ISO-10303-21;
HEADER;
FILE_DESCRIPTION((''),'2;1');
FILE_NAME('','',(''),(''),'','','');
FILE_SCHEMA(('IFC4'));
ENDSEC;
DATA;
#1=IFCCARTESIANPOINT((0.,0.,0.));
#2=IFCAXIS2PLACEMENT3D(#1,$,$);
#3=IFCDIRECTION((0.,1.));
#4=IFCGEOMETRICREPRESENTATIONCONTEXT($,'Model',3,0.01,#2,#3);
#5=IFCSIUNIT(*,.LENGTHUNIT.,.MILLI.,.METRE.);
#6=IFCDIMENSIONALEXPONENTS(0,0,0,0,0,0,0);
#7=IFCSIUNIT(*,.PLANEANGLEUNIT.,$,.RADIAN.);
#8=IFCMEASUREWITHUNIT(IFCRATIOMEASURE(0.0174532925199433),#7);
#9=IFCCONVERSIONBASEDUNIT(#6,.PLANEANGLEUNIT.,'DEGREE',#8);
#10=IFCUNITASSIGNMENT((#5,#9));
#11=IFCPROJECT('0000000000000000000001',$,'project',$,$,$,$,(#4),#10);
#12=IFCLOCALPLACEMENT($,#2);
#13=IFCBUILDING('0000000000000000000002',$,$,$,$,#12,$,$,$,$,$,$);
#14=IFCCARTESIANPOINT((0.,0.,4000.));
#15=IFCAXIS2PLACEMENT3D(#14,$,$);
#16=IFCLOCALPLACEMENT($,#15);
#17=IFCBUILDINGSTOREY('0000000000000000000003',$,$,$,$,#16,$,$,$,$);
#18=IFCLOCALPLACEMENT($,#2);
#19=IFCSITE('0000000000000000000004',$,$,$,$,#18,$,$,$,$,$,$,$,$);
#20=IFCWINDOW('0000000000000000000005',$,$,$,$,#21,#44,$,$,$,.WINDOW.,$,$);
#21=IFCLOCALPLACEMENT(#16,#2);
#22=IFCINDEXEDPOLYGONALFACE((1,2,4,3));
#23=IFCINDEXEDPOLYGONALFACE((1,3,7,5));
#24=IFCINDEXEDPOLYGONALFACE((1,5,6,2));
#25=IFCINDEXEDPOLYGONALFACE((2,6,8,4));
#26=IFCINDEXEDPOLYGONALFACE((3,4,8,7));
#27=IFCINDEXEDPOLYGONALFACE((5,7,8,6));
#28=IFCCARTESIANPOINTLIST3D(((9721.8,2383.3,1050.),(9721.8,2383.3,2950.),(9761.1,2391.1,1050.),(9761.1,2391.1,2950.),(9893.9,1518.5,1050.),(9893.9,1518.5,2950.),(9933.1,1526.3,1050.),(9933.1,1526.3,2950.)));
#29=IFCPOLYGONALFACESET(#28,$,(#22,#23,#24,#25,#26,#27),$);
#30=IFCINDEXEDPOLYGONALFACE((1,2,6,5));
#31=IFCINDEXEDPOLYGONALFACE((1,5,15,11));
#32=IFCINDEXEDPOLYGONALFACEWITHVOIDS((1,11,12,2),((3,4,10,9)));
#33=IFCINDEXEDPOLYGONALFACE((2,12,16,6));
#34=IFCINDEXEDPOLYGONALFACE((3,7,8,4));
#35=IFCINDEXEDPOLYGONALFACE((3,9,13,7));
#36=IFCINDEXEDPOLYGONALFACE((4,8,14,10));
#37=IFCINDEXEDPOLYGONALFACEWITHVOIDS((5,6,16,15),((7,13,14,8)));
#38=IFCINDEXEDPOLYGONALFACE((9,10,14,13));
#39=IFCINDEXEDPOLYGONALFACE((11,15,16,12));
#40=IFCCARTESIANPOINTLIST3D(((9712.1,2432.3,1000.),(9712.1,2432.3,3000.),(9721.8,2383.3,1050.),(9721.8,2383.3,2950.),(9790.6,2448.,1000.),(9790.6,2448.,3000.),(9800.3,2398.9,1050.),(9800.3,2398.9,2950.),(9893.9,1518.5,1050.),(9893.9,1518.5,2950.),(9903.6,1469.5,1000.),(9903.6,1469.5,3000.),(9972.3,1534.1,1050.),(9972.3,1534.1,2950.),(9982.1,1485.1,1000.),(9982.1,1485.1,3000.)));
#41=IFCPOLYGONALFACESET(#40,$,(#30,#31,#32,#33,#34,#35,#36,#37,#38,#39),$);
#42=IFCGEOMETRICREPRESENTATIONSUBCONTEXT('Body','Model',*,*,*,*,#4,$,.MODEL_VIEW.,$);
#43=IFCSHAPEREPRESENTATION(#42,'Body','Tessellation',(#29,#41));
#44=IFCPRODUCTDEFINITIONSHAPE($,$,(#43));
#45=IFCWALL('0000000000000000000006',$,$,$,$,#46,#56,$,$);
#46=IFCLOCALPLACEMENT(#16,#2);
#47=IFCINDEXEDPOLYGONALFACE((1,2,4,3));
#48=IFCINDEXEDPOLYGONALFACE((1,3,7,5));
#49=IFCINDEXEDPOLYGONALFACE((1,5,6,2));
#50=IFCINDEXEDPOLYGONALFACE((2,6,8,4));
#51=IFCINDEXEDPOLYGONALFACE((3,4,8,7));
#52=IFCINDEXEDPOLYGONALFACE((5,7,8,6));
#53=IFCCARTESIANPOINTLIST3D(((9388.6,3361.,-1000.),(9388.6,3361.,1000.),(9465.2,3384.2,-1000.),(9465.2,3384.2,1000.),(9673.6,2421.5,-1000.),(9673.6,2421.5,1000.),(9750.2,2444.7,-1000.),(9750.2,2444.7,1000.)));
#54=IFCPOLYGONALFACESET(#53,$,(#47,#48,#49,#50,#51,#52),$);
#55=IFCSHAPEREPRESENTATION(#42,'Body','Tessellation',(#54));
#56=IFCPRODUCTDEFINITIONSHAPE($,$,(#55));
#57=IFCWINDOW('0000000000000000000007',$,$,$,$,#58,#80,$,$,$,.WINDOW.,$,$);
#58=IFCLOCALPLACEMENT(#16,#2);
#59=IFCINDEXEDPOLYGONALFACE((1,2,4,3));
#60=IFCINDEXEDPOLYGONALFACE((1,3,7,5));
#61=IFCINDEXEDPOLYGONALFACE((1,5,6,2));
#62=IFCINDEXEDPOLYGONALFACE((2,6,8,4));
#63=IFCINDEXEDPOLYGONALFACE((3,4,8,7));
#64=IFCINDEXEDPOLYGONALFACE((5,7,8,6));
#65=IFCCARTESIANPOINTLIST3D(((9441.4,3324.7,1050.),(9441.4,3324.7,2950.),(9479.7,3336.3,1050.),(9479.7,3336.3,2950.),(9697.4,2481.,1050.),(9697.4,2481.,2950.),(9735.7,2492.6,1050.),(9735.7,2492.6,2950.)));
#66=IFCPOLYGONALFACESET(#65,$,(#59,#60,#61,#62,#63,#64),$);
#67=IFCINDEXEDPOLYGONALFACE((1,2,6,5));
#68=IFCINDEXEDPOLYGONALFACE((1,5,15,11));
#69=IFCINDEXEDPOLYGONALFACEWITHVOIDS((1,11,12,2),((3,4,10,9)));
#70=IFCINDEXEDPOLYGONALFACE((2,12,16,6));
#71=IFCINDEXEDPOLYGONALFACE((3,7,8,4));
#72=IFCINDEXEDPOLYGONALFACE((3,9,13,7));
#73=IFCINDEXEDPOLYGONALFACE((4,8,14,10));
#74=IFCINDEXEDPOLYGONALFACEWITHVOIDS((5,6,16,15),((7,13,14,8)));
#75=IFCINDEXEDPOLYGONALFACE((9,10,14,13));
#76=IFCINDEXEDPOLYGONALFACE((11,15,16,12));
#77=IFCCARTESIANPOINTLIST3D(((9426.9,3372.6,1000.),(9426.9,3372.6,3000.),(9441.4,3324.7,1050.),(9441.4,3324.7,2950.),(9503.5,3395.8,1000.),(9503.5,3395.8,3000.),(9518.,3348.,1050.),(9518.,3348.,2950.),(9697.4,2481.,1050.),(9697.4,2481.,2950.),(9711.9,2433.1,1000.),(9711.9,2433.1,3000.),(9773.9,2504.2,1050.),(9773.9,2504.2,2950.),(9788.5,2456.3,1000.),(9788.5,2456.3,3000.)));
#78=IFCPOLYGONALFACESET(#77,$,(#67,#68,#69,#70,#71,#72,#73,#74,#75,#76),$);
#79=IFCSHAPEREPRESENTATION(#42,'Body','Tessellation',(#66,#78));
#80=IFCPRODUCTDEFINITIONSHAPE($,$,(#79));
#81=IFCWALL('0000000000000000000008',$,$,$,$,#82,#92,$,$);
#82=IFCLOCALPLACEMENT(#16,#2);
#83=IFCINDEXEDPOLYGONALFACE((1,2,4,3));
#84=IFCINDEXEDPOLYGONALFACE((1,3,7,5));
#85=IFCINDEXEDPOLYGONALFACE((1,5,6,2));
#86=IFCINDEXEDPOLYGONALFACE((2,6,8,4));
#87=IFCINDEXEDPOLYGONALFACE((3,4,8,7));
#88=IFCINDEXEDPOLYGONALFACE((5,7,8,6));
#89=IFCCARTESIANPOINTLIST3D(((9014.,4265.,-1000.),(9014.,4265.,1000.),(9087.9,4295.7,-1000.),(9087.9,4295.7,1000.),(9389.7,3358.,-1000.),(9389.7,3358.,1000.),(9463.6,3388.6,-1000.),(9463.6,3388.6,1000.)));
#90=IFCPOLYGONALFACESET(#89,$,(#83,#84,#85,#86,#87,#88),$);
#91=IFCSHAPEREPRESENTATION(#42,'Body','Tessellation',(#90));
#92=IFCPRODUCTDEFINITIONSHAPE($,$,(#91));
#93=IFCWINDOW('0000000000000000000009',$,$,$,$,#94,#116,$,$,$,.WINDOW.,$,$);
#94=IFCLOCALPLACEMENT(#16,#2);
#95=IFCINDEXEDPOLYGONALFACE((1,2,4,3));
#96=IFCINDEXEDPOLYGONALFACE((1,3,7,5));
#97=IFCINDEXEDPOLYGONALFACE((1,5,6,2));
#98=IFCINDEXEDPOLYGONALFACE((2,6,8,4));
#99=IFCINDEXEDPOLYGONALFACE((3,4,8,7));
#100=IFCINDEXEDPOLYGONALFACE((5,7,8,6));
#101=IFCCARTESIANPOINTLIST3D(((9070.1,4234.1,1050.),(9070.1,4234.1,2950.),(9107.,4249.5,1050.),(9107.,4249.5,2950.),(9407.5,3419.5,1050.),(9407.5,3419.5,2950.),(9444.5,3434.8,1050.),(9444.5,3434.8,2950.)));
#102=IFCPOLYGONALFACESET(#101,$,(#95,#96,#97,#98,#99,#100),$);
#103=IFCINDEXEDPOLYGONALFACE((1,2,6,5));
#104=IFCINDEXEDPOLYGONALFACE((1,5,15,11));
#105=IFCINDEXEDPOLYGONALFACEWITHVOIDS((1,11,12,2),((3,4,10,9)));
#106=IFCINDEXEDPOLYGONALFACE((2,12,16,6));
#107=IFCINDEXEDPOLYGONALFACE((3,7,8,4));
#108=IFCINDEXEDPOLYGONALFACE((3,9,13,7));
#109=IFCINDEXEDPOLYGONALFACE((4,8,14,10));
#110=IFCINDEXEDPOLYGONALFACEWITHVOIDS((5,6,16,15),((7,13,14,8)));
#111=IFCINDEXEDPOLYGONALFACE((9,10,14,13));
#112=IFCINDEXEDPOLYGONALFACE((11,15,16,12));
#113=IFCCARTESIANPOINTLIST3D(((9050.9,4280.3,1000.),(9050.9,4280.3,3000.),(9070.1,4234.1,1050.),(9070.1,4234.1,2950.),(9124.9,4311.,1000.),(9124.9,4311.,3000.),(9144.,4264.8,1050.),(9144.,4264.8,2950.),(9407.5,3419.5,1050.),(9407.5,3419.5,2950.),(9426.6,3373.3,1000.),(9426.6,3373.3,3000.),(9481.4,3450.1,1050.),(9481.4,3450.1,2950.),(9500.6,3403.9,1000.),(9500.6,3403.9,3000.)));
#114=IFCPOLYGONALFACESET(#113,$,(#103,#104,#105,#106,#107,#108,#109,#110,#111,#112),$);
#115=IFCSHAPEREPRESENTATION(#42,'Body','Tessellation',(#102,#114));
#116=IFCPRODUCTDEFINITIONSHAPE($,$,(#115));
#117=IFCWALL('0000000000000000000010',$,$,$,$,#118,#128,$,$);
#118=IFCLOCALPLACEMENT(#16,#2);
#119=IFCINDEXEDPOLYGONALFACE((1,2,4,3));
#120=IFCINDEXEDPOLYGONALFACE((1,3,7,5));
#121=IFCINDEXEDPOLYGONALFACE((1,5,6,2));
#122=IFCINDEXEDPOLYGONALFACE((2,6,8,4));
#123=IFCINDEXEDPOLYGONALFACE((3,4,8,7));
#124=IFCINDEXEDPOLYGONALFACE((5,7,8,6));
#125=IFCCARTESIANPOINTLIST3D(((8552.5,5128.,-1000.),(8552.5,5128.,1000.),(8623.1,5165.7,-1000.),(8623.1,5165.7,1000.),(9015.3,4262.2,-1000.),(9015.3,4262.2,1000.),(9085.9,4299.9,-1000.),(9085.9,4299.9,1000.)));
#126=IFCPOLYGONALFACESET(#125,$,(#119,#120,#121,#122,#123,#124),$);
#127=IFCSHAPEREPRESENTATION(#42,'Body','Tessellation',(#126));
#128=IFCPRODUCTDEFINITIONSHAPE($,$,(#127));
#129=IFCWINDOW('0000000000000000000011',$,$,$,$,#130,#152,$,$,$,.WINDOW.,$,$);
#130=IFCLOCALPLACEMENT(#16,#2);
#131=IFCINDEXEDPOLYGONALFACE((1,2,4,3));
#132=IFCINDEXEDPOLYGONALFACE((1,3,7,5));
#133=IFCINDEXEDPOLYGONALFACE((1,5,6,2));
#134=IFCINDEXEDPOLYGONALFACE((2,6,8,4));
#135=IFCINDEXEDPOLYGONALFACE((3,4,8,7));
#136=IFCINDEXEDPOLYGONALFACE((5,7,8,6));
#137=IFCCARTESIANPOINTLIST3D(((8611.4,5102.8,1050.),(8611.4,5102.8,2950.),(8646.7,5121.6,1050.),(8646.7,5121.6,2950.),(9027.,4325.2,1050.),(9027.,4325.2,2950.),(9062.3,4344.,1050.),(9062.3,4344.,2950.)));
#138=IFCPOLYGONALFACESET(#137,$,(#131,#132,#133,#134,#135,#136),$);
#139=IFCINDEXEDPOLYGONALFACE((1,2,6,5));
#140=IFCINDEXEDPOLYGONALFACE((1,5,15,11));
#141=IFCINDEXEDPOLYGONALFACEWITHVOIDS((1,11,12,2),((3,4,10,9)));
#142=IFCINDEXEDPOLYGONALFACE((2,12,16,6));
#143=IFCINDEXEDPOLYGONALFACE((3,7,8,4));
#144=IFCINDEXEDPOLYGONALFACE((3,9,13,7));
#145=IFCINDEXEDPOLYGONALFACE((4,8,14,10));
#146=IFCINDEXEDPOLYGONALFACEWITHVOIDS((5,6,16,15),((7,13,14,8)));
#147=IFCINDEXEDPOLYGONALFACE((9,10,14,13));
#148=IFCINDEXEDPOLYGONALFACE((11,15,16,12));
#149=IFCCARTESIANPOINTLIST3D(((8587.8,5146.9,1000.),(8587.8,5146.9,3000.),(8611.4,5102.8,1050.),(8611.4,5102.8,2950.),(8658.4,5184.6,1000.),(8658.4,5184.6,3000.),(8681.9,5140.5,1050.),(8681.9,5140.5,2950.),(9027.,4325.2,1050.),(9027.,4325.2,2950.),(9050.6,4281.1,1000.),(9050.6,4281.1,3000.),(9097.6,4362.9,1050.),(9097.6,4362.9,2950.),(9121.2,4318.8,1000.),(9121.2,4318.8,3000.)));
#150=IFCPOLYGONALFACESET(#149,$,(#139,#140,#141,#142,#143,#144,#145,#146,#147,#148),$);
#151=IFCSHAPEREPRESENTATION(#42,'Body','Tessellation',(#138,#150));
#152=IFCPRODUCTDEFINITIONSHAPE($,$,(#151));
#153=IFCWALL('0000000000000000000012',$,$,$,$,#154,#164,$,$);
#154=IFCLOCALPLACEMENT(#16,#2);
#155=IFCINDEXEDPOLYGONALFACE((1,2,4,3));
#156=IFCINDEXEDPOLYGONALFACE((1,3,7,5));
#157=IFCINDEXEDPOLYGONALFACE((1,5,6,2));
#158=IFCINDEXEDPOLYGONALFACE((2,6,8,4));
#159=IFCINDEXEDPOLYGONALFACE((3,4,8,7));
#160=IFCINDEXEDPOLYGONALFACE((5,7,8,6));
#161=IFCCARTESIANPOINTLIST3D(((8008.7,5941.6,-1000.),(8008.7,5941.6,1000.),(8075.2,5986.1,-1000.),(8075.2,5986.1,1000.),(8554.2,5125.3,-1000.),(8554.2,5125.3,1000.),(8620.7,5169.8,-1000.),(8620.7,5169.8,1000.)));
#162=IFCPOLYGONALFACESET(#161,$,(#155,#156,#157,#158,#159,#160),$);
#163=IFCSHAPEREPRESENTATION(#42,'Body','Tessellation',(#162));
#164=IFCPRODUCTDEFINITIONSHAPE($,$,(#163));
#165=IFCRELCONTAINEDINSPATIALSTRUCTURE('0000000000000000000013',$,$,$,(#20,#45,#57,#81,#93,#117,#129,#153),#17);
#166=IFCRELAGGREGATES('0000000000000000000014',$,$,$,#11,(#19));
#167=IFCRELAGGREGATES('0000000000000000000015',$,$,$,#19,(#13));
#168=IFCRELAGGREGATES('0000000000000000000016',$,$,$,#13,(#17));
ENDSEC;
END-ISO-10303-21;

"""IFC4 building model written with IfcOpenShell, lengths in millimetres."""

from ifc_helpers import new_model, entity, si_unit, converted_unit, direction, frame, origin, origin_2d, place, context, subcontext, project, spatial, rectangle, extrude, element, save


model = new_model("IFC4")

# Units and contexts
model_context = context("Model", 3, precision=0.01, world=origin(), true_north=direction((0.0, 1.0)))
body_context = subcontext(model_context, "Body", "Model", "MODEL_VIEW")
ifc_project = project(units=[si_unit("LENGTHUNIT", "METRE", prefix="MILLI"), converted_unit("PLANEANGLEUNIT", "DEGREE", entity("IfcRatioMeasure", 0.0174532925199433), si_unit("PLANEANGLEUNIT", "RADIAN"), dimensions=[0, 0, 0, 0, 0, 0, 0])], contexts=[model_context])

# Site, building, storey
site_placement = place(None, origin())
site = spatial("IfcSite", under=ifc_project, at=site_placement)
building_placement = place(None, origin())
building = spatial("IfcBuilding", under=site, at=building_placement)
storey_placement = place(None, frame((0.0, 0.0, 4000.0)))
storey = spatial("IfcBuildingStorey", under=building, at=storey_placement)

# Shared definitions
cartesian_point_1 = entity("IfcCartesianPoint", [-440.9, -950.0])
shared_polyline = entity("IfcPolyline", [cartesian_point_1, entity("IfcCartesianPoint", [-440.9, 950.0]), entity("IfcCartesianPoint", [-440.9, 950.0]), entity("IfcCartesianPoint", [440.9, 950.0]), entity("IfcCartesianPoint", [440.9, 950.0]), entity("IfcCartesianPoint", [440.9, -950.0]), entity("IfcCartesianPoint", [440.9, -950.0]), entity("IfcCartesianPoint", [-440.9, -950.0]), cartesian_point_1])

# Window
window_1_placement = place(storey_placement, frame((9807.9, 1950.9, 2000.0), z_axis=(0.0, 0.0, 1.0), x_axis=(-1950.903274, 9807.852793, 0.0)))
cartesian_point_2 = entity("IfcCartesianPoint", [-490.9, -1000.0])
element("IfcWindow", 1, at=window_1_placement, inside=storey, PredefinedType="WINDOW", context=body_context, shape_type="SweptSolid", body=[
    entity("IfcExtrudedAreaSolid", entity("IfcArbitraryClosedProfileDef", "AREA", None, shared_polyline), entity("IfcAxis2Placement3D", entity("IfcCartesianPoint", [0.0, 0.0, 0.0]), entity("IfcDirection", [0.0, -1.0, 0.0]), entity("IfcDirection", [1.0, 0.0, 0.0])), entity("IfcDirection", [0.0, 0.0, 1.0]), 40.0),
    entity("IfcExtrudedAreaSolid", entity("IfcArbitraryProfileDefWithVoids", "AREA", None, entity("IfcPolyline", [cartesian_point_2, entity("IfcCartesianPoint", [-490.9, 1000.0]), entity("IfcCartesianPoint", [-490.9, 1000.0]), entity("IfcCartesianPoint", [490.9, 1000.0]), entity("IfcCartesianPoint", [490.9, 1000.0]), entity("IfcCartesianPoint", [490.9, -1000.0]), entity("IfcCartesianPoint", [490.9, -1000.0]), entity("IfcCartesianPoint", [-490.9, -1000.0]), cartesian_point_2]), [shared_polyline]), entity("IfcAxis2Placement3D", entity("IfcCartesianPoint", [0.0, 0.0, 0.0]), entity("IfcDirection", [0.0, -1.0, 0.0]), entity("IfcDirection", [1.0, 0.0, 0.0])), entity("IfcDirection", [0.0, 0.0, 1.0]), 80.0),
])

# Wall
wall_1_placement = place(storey_placement, frame((9569.4, 2902.8, -1000.0), z_axis=(0.0, 0.0, 1.0), x_axis=(-2902.84678, 9569.403355, 0.0)))
element("IfcWall", 2, at=wall_1_placement, inside=storey, context=body_context, shape_type="SweptSolid", body=[
    extrude(rectangle(XDim=981.7, YDim=80.0, at=origin_2d()), origin(), (0.0, 0.0, 1.0), 2000.0),
])

# Window
window_2_placement = place(storey_placement, frame((9569.4, 2902.8, 2000.0), z_axis=(0.0, 0.0, 1.0), x_axis=(-2902.84678, 9569.403355, 0.0)))
cartesian_point_3 = entity("IfcCartesianPoint", [-490.9, -1000.0])
element("IfcWindow", 3, at=window_2_placement, inside=storey, PredefinedType="WINDOW", context=body_context, shape_type="SweptSolid", body=[
    entity("IfcExtrudedAreaSolid", entity("IfcArbitraryClosedProfileDef", "AREA", None, shared_polyline), entity("IfcAxis2Placement3D", entity("IfcCartesianPoint", [0.0, 0.0, 0.0]), entity("IfcDirection", [0.0, -1.0, 0.0]), entity("IfcDirection", [1.0, 0.0, 0.0])), entity("IfcDirection", [0.0, 0.0, 1.0]), 40.0),
    entity("IfcExtrudedAreaSolid", entity("IfcArbitraryProfileDefWithVoids", "AREA", None, entity("IfcPolyline", [cartesian_point_3, entity("IfcCartesianPoint", [-490.9, 1000.0]), entity("IfcCartesianPoint", [-490.9, 1000.0]), entity("IfcCartesianPoint", [490.9, 1000.0]), entity("IfcCartesianPoint", [490.9, 1000.0]), entity("IfcCartesianPoint", [490.9, -1000.0]), entity("IfcCartesianPoint", [490.9, -1000.0]), entity("IfcCartesianPoint", [-490.9, -1000.0]), cartesian_point_3]), [shared_polyline]), entity("IfcAxis2Placement3D", entity("IfcCartesianPoint", [0.0, 0.0, 0.0]), entity("IfcDirection", [0.0, -1.0, 0.0]), entity("IfcDirection", [1.0, 0.0, 0.0])), entity("IfcDirection", [0.0, 0.0, 1.0]), 80.0),
])

# Wall
wall_2_placement = place(storey_placement, frame((9238.8, 3826.8, -1000.0), z_axis=(0.0, 0.0, 1.0), x_axis=(-3826.834425, 9238.795283, 0.0)))
element("IfcWall", 4, at=wall_2_placement, inside=storey, context=body_context, shape_type="SweptSolid", body=[
    extrude(rectangle(XDim=981.7, YDim=80.0, at=origin_2d()), origin(), (0.0, 0.0, 1.0), 2000.0),
])

# Window
window_3_placement = place(storey_placement, frame((9238.8, 3826.8, 2000.0), z_axis=(0.0, 0.0, 1.0), x_axis=(-3826.834425, 9238.795283, 0.0)))
cartesian_point_4 = entity("IfcCartesianPoint", [-490.9, -1000.0])
element("IfcWindow", 5, at=window_3_placement, inside=storey, PredefinedType="WINDOW", context=body_context, shape_type="SweptSolid", body=[
    entity("IfcExtrudedAreaSolid", entity("IfcArbitraryClosedProfileDef", "AREA", None, shared_polyline), entity("IfcAxis2Placement3D", entity("IfcCartesianPoint", [0.0, 0.0, 0.0]), entity("IfcDirection", [0.0, -1.0, 0.0]), entity("IfcDirection", [1.0, 0.0, 0.0])), entity("IfcDirection", [0.0, 0.0, 1.0]), 40.0),
    entity("IfcExtrudedAreaSolid", entity("IfcArbitraryProfileDefWithVoids", "AREA", None, entity("IfcPolyline", [cartesian_point_4, entity("IfcCartesianPoint", [-490.9, 1000.0]), entity("IfcCartesianPoint", [-490.9, 1000.0]), entity("IfcCartesianPoint", [490.9, 1000.0]), entity("IfcCartesianPoint", [490.9, 1000.0]), entity("IfcCartesianPoint", [490.9, -1000.0]), entity("IfcCartesianPoint", [490.9, -1000.0]), entity("IfcCartesianPoint", [-490.9, -1000.0]), cartesian_point_4]), [shared_polyline]), entity("IfcAxis2Placement3D", entity("IfcCartesianPoint", [0.0, 0.0, 0.0]), entity("IfcDirection", [0.0, -1.0, 0.0]), entity("IfcDirection", [1.0, 0.0, 0.0])), entity("IfcDirection", [0.0, 0.0, 1.0]), 80.0),
])

# Wall
wall_3_placement = place(storey_placement, frame((8819.2, 4714.0, -1000.0), z_axis=(0.0, 0.0, 1.0), x_axis=(-4713.967292, 8819.212684, 0.0)))
element("IfcWall", 6, at=wall_3_placement, inside=storey, context=body_context, shape_type="SweptSolid", body=[
    extrude(rectangle(XDim=981.7, YDim=80.0, at=origin_2d()), origin(), (0.0, 0.0, 1.0), 2000.0),
])

# Window
window_4_placement = place(storey_placement, frame((8819.2, 4714.0, 2000.0), z_axis=(0.0, 0.0, 1.0), x_axis=(-4713.967292, 8819.212684, 0.0)))
cartesian_point_5 = entity("IfcCartesianPoint", [-490.9, -1000.0])
element("IfcWindow", 7, at=window_4_placement, inside=storey, PredefinedType="WINDOW", context=body_context, shape_type="SweptSolid", body=[
    entity("IfcExtrudedAreaSolid", entity("IfcArbitraryClosedProfileDef", "AREA", None, shared_polyline), entity("IfcAxis2Placement3D", entity("IfcCartesianPoint", [0.0, 0.0, 0.0]), entity("IfcDirection", [0.0, -1.0, 0.0]), entity("IfcDirection", [1.0, 0.0, 0.0])), entity("IfcDirection", [0.0, 0.0, 1.0]), 40.0),
    entity("IfcExtrudedAreaSolid", entity("IfcArbitraryProfileDefWithVoids", "AREA", None, entity("IfcPolyline", [cartesian_point_5, entity("IfcCartesianPoint", [-490.9, 1000.0]), entity("IfcCartesianPoint", [-490.9, 1000.0]), entity("IfcCartesianPoint", [490.9, 1000.0]), entity("IfcCartesianPoint", [490.9, 1000.0]), entity("IfcCartesianPoint", [490.9, -1000.0]), entity("IfcCartesianPoint", [490.9, -1000.0]), entity("IfcCartesianPoint", [-490.9, -1000.0]), cartesian_point_5]), [shared_polyline]), entity("IfcAxis2Placement3D", entity("IfcCartesianPoint", [0.0, 0.0, 0.0]), entity("IfcDirection", [0.0, -1.0, 0.0]), entity("IfcDirection", [1.0, 0.0, 0.0])), entity("IfcDirection", [0.0, 0.0, 1.0]), 80.0),
])

# Wall
wall_4_placement = place(storey_placement, frame((8314.7, 5555.7, -1000.0), z_axis=(0.0, 0.0, 1.0), x_axis=(-5555.702343, 8314.696115, 0.0)))
element("IfcWall", 8, at=wall_4_placement, inside=storey, context=body_context, shape_type="SweptSolid", body=[
    extrude(rectangle(XDim=981.7, YDim=80.0, at=origin_2d()), origin(), (0.0, 0.0, 1.0), 2000.0),
])

save(model, "model.ifc")
